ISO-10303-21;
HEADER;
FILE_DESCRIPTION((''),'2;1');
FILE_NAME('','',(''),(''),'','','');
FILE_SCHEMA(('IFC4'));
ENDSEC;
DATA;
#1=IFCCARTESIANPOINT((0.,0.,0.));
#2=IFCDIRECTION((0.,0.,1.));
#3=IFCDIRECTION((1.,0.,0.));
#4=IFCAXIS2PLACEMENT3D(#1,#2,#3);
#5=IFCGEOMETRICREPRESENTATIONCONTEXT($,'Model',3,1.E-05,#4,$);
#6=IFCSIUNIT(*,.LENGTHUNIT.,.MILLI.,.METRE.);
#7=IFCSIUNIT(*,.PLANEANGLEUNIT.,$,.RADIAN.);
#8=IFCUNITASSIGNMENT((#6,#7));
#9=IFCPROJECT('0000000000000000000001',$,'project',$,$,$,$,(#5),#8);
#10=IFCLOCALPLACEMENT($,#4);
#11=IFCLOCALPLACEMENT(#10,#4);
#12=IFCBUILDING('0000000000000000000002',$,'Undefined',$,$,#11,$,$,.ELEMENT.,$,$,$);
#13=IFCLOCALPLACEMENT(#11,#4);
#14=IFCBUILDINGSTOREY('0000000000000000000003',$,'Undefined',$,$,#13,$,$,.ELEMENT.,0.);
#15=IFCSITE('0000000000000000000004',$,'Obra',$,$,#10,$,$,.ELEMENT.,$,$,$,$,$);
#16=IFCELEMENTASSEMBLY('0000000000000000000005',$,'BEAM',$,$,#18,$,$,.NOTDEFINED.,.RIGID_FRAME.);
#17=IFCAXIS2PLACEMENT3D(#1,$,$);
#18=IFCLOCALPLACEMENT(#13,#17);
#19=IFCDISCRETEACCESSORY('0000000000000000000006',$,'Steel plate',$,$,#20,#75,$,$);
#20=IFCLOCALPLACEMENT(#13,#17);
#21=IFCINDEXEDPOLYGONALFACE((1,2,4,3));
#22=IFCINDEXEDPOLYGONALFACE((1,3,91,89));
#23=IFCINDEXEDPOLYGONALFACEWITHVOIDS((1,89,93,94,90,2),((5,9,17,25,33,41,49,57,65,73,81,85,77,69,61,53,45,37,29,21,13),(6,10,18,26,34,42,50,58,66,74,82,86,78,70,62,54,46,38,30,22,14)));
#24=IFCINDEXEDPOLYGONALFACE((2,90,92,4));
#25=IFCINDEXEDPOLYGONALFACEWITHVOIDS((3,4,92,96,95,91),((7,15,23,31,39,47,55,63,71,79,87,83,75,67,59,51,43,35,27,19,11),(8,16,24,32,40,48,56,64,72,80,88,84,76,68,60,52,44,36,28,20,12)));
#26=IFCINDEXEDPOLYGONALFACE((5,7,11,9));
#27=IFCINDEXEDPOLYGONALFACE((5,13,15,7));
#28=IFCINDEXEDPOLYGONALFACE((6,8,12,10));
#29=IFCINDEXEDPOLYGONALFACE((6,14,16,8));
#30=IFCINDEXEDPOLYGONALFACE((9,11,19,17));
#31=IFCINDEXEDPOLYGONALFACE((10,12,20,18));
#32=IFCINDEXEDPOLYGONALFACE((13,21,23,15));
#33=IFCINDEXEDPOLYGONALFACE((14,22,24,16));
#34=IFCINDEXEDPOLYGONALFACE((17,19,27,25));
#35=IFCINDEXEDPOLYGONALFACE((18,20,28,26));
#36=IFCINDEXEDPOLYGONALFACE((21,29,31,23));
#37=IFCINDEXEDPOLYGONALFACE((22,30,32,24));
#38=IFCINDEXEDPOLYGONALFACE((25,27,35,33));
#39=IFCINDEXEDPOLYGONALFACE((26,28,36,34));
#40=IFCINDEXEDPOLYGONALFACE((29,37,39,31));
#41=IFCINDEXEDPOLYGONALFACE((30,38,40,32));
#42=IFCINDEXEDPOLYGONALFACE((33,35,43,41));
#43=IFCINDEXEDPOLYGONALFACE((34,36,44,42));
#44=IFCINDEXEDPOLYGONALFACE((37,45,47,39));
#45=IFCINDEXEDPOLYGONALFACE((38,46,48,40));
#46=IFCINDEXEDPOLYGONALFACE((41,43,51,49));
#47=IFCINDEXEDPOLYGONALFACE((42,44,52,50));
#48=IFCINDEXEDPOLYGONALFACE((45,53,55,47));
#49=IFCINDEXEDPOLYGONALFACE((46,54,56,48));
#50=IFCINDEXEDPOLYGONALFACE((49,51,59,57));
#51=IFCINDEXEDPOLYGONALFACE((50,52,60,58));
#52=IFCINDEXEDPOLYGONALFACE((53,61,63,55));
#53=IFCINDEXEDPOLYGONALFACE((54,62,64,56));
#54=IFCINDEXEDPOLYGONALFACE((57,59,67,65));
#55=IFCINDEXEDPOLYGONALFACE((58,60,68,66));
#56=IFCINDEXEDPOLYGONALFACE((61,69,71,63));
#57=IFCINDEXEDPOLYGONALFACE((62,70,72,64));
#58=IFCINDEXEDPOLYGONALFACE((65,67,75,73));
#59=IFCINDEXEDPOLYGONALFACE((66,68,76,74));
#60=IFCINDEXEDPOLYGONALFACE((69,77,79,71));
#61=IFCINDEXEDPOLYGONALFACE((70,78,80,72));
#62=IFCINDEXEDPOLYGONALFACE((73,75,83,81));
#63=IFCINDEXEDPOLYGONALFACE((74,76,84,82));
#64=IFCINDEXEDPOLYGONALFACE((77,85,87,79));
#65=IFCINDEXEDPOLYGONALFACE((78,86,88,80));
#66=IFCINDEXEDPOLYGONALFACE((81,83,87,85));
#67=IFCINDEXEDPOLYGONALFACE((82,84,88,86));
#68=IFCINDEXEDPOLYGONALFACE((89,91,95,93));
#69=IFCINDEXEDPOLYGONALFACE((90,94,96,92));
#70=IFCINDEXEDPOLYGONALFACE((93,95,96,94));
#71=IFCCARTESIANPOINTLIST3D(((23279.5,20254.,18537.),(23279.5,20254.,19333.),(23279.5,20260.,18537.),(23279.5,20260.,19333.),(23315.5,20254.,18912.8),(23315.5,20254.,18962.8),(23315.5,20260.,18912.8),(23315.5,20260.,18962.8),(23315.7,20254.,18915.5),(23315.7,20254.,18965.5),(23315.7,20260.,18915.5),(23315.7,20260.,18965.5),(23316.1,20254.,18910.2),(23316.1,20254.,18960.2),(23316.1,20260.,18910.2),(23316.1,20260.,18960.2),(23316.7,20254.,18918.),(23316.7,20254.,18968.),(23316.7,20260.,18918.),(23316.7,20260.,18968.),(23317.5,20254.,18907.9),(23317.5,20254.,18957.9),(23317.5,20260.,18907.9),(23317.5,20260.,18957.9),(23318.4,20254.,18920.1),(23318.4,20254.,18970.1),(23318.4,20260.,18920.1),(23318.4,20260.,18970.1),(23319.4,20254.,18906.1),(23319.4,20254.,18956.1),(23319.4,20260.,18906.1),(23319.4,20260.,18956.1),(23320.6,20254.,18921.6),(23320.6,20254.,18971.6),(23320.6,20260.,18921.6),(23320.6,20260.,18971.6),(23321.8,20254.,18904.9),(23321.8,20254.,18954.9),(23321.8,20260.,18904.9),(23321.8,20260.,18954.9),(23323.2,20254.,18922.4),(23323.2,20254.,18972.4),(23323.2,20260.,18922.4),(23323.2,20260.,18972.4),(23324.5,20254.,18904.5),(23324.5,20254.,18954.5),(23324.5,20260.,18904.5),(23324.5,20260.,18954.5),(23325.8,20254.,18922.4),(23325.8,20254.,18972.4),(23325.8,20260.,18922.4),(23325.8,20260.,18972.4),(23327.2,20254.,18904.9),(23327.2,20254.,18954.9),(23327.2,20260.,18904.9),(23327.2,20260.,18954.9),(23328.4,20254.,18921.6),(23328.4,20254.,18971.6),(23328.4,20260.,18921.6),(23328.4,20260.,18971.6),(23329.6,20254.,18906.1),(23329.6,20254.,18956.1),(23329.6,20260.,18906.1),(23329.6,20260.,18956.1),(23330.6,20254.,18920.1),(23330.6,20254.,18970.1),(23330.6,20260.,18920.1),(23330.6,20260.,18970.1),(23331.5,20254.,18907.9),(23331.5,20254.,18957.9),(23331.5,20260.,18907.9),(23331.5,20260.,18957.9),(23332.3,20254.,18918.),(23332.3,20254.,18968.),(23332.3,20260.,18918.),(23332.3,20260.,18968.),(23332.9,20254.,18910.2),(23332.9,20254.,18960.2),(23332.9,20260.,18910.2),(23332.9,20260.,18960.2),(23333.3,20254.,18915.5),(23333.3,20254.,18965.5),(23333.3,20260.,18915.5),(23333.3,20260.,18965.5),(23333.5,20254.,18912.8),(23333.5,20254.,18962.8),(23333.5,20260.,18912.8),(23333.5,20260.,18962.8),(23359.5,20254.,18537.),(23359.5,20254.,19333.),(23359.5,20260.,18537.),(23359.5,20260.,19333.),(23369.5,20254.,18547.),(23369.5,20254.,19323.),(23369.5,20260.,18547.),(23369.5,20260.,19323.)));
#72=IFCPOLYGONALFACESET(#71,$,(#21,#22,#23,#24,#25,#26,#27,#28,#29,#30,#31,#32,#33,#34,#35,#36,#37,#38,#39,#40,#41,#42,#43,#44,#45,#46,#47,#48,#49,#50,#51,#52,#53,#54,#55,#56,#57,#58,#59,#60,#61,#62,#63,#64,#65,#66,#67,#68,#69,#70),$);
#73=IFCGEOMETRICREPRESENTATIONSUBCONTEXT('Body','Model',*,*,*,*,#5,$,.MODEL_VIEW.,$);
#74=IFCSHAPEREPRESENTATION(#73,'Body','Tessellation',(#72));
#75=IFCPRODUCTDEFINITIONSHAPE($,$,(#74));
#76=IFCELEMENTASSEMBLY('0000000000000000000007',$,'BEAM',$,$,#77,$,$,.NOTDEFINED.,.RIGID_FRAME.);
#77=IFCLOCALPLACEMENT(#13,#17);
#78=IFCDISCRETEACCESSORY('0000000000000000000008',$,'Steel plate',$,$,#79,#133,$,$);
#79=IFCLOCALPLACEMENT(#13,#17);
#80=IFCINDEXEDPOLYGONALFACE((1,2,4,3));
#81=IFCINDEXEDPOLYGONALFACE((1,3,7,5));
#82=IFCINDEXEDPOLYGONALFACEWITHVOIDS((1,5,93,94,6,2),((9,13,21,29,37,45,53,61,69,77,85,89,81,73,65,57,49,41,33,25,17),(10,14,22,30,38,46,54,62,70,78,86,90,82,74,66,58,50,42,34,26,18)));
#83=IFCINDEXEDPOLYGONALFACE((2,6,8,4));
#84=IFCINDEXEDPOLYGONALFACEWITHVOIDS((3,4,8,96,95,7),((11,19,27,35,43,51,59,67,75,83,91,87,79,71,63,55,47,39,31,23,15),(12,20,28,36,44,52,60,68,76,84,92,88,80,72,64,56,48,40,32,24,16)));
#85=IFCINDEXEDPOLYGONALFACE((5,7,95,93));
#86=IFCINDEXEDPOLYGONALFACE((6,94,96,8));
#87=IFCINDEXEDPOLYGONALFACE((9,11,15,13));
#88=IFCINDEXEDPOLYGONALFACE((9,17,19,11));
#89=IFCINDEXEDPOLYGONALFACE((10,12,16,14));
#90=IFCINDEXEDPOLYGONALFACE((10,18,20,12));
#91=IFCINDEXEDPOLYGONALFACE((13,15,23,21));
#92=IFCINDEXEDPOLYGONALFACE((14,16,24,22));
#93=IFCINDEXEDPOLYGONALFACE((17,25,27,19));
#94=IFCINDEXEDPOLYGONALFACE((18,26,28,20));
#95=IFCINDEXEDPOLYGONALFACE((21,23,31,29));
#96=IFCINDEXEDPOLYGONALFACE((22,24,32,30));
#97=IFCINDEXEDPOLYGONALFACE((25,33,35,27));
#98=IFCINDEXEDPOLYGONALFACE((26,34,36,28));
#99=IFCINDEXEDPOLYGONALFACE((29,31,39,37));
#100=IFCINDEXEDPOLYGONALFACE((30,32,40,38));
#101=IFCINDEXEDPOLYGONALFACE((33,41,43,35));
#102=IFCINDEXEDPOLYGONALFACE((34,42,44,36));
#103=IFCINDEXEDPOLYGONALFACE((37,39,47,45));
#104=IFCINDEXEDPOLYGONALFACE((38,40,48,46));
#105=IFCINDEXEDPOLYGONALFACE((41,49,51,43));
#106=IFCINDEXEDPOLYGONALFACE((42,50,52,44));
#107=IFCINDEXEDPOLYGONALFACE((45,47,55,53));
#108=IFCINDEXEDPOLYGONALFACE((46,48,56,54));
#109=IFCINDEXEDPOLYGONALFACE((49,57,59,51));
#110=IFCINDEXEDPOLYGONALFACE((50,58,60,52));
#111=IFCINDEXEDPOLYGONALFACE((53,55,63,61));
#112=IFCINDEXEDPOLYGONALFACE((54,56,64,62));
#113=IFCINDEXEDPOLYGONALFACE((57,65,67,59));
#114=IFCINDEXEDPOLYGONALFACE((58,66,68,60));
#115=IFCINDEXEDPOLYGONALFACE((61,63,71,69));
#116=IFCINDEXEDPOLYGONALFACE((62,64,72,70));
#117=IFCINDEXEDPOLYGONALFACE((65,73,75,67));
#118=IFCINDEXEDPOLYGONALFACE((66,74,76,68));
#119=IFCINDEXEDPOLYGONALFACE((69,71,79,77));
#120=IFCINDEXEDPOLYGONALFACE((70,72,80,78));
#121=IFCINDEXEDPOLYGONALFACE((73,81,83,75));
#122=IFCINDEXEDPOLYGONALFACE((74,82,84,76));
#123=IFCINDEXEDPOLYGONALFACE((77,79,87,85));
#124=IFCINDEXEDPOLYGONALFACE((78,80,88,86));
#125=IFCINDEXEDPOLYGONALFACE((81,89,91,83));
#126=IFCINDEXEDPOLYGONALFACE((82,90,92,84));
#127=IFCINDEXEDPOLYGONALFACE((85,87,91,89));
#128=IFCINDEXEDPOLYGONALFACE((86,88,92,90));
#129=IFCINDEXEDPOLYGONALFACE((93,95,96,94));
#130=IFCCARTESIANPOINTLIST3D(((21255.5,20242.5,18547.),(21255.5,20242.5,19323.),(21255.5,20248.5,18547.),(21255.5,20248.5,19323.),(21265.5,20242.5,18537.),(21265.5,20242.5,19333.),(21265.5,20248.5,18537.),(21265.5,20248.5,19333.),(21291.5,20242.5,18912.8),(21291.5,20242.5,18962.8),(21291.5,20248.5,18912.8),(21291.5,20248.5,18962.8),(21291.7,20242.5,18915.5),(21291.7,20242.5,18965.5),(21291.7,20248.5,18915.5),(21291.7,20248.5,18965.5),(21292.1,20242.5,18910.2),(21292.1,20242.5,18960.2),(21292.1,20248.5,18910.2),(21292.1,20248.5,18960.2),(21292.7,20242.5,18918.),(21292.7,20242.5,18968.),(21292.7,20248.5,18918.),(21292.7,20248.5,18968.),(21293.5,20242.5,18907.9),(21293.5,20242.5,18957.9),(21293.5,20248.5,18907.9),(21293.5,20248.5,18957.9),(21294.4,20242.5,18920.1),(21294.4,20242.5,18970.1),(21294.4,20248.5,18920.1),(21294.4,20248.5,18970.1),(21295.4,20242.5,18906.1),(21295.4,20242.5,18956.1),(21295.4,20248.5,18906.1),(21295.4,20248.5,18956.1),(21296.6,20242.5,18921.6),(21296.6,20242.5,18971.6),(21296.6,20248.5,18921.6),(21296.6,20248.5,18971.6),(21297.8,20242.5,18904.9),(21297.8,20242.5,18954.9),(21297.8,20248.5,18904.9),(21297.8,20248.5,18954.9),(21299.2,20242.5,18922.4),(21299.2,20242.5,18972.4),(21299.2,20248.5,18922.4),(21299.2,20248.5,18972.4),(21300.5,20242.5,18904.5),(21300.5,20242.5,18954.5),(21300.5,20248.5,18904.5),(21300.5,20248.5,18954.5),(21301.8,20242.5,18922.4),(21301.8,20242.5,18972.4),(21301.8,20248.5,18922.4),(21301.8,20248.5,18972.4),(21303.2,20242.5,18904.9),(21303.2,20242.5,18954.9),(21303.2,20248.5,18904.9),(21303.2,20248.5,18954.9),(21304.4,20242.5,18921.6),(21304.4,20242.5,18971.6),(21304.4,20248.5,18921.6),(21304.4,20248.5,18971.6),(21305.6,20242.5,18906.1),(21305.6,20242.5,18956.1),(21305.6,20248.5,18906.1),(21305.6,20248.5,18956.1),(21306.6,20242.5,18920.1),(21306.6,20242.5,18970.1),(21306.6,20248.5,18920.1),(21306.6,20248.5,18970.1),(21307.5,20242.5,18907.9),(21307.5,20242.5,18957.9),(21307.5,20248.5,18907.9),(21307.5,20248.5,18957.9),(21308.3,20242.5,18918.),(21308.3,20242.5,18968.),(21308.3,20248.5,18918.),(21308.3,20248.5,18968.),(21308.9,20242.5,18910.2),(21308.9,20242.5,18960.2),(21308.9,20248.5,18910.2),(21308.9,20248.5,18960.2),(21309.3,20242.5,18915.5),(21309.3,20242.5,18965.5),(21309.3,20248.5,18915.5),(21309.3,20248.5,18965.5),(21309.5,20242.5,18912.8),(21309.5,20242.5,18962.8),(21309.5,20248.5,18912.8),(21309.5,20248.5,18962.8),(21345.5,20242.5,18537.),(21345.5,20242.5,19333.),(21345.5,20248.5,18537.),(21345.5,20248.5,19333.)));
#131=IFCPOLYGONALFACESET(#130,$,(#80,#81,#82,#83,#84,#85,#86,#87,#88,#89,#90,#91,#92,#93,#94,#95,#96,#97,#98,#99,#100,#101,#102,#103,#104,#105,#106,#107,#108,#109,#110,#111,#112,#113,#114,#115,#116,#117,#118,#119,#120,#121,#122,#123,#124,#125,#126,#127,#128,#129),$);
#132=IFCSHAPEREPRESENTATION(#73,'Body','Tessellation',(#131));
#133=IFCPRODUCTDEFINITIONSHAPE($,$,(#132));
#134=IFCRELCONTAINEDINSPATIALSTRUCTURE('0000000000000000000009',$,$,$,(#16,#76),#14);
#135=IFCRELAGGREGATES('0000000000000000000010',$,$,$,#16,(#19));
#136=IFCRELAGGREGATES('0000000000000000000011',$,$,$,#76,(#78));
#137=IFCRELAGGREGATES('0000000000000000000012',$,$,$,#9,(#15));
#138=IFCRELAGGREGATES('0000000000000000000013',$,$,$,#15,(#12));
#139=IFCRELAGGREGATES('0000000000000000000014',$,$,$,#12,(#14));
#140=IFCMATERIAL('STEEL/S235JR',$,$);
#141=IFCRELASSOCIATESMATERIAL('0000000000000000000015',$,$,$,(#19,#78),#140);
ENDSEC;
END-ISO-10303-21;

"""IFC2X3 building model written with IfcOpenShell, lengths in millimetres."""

from ifc_helpers import new_model, si_unit, frame, origin_with_axes, origin_2d_with_axis, place, context, subcontext, project, spatial, polyline, circle, outline, extrude, source, transform, mapped, material, element, aggregate, save


model = new_model("IFC2X3")

# Units and contexts
model_context = context("Model", 3, precision=1e-05, world=origin_with_axes())
body_context = subcontext(model_context, "Body", "Model", "MODEL_VIEW")
ifc_project = project(units=[si_unit("LENGTHUNIT", "METRE", prefix="MILLI"), si_unit("PLANEANGLEUNIT", "RADIAN")], contexts=[model_context])

# Site, building, storey
site_placement = place(None, origin_with_axes())
site = spatial("IfcSite", under=ifc_project, at=site_placement, Name="Obra", CompositionType="ELEMENT")
building_placement = place(site_placement, origin_with_axes())
building = spatial("IfcBuilding", under=site, at=building_placement, Name="Undefined", CompositionType="ELEMENT")
storey_placement = place(building_placement, origin_with_axes())
storey = spatial("IfcBuildingStorey", under=building, at=storey_placement, Name="Undefined", CompositionType="ELEMENT", Elevation=0.0)

# Shared definitions
ifc_material_1 = material(Name="STEEL/S235JR")

# Element assemblies, discrete accessories, openings
assembly_1_placement = place(storey_placement, origin_with_axes())
assembly_1 = element("IfcElementAssembly", 1, at=assembly_1_placement, inside=storey, Name="BEAM", AssemblyPlace="NOTDEFINED", PredefinedType="RIGID_FRAME")
discrete_accessory_1_placement = place(assembly_1_placement, frame((23279.5, 20257.0, 18537.0), z_axis=(0.0, -1.0, 0.0), x_axis=(1.0, 0.0, 0.0)))
discrete_accessory_1 = element("IfcDiscreteAccessory", 2, at=discrete_accessory_1_placement, material=ifc_material_1, Name="Steel plate", context=body_context, shape_type="SweptSolid", body=[
    extrude(outline(polyline([(0.0, 0.0), (80.0, 0.0), (90.0, 10.0), (90.0, 786.0), (80.0, 796.0), (0.0, 796.0), (0.0, 0.0)])), frame((0.0, 0.0, -3.0), z_axis=(0.0, 0.0, 1.0), x_axis=(1.0, 0.0, 0.0)), (0.0, 0.0, 1.0), 6.0),
])
shared_shape_1 = source(origin_with_axes(), body_context, "Body", "SweptSolid", [
    extrude(circle(Radius=9.0, at=origin_2d_with_axis()), frame((0.0, -8.8, 0.0), z_axis=(0.0, 1.0, 0.0), x_axis=(1.0, 0.0, 0.0)), (0.0, 0.0, 1.0), 6.2),
])
opening_1_placement = place(assembly_1_placement, frame((23359.5, 20251.3, 19005.0), z_axis=(-1.0, 0.0, 0.0), x_axis=(0.0, 0.0, -1.0)))
element("IfcOpeningElement", 3, at=opening_1_placement, cuts=discrete_accessory_1, ObjectType="Opening", context=body_context, shape_type="MappedRepresentation", body=[
    mapped(shared_shape_1, transform((41.5, 0.0, 35.0))),
    mapped(shared_shape_1, transform((91.5, 0.0, 35.0))),
])
aggregate(assembly_1, [discrete_accessory_1])
assembly_2_placement = place(storey_placement, origin_with_axes())
assembly_2 = element("IfcElementAssembly", 4, at=assembly_2_placement, inside=storey, Name="BEAM", AssemblyPlace="NOTDEFINED", PredefinedType="RIGID_FRAME")
discrete_accessory_2_placement = place(assembly_2_placement, frame((21345.5, 20245.5, 18537.0), z_axis=(0.0, 1.0, 0.0), x_axis=(-1.0, 0.0, 0.0)))
discrete_accessory_2 = element("IfcDiscreteAccessory", 5, at=discrete_accessory_2_placement, material=ifc_material_1, Name="Steel plate", context=body_context, shape_type="SweptSolid", body=[
    extrude(outline(polyline([(0.0, 0.0), (80.0, 0.0), (90.0, 10.0), (90.0, 786.0), (80.0, 796.0), (0.0, 796.0), (0.0, 0.0)])), frame((0.0, 0.0, -3.0), z_axis=(0.0, 0.0, 1.0), x_axis=(1.0, 0.0, 0.0)), (0.0, 0.0, 1.0), 6.0),
])
opening_2_placement = place(assembly_2_placement, frame((21265.5, 20251.3, 19005.0), z_axis=(1.0, 0.0, 0.0), x_axis=(0.0, 0.0, -1.0)))
element("IfcOpeningElement", 6, at=opening_2_placement, cuts=discrete_accessory_2, ObjectType="Opening", context=body_context, shape_type="MappedRepresentation", body=[
    mapped(shared_shape_1, transform((41.5, 0.0, 35.0))),
    mapped(shared_shape_1, transform((91.5, 0.0, 35.0))),
])
aggregate(assembly_2, [discrete_accessory_2])

save(model, "model.ifc")
